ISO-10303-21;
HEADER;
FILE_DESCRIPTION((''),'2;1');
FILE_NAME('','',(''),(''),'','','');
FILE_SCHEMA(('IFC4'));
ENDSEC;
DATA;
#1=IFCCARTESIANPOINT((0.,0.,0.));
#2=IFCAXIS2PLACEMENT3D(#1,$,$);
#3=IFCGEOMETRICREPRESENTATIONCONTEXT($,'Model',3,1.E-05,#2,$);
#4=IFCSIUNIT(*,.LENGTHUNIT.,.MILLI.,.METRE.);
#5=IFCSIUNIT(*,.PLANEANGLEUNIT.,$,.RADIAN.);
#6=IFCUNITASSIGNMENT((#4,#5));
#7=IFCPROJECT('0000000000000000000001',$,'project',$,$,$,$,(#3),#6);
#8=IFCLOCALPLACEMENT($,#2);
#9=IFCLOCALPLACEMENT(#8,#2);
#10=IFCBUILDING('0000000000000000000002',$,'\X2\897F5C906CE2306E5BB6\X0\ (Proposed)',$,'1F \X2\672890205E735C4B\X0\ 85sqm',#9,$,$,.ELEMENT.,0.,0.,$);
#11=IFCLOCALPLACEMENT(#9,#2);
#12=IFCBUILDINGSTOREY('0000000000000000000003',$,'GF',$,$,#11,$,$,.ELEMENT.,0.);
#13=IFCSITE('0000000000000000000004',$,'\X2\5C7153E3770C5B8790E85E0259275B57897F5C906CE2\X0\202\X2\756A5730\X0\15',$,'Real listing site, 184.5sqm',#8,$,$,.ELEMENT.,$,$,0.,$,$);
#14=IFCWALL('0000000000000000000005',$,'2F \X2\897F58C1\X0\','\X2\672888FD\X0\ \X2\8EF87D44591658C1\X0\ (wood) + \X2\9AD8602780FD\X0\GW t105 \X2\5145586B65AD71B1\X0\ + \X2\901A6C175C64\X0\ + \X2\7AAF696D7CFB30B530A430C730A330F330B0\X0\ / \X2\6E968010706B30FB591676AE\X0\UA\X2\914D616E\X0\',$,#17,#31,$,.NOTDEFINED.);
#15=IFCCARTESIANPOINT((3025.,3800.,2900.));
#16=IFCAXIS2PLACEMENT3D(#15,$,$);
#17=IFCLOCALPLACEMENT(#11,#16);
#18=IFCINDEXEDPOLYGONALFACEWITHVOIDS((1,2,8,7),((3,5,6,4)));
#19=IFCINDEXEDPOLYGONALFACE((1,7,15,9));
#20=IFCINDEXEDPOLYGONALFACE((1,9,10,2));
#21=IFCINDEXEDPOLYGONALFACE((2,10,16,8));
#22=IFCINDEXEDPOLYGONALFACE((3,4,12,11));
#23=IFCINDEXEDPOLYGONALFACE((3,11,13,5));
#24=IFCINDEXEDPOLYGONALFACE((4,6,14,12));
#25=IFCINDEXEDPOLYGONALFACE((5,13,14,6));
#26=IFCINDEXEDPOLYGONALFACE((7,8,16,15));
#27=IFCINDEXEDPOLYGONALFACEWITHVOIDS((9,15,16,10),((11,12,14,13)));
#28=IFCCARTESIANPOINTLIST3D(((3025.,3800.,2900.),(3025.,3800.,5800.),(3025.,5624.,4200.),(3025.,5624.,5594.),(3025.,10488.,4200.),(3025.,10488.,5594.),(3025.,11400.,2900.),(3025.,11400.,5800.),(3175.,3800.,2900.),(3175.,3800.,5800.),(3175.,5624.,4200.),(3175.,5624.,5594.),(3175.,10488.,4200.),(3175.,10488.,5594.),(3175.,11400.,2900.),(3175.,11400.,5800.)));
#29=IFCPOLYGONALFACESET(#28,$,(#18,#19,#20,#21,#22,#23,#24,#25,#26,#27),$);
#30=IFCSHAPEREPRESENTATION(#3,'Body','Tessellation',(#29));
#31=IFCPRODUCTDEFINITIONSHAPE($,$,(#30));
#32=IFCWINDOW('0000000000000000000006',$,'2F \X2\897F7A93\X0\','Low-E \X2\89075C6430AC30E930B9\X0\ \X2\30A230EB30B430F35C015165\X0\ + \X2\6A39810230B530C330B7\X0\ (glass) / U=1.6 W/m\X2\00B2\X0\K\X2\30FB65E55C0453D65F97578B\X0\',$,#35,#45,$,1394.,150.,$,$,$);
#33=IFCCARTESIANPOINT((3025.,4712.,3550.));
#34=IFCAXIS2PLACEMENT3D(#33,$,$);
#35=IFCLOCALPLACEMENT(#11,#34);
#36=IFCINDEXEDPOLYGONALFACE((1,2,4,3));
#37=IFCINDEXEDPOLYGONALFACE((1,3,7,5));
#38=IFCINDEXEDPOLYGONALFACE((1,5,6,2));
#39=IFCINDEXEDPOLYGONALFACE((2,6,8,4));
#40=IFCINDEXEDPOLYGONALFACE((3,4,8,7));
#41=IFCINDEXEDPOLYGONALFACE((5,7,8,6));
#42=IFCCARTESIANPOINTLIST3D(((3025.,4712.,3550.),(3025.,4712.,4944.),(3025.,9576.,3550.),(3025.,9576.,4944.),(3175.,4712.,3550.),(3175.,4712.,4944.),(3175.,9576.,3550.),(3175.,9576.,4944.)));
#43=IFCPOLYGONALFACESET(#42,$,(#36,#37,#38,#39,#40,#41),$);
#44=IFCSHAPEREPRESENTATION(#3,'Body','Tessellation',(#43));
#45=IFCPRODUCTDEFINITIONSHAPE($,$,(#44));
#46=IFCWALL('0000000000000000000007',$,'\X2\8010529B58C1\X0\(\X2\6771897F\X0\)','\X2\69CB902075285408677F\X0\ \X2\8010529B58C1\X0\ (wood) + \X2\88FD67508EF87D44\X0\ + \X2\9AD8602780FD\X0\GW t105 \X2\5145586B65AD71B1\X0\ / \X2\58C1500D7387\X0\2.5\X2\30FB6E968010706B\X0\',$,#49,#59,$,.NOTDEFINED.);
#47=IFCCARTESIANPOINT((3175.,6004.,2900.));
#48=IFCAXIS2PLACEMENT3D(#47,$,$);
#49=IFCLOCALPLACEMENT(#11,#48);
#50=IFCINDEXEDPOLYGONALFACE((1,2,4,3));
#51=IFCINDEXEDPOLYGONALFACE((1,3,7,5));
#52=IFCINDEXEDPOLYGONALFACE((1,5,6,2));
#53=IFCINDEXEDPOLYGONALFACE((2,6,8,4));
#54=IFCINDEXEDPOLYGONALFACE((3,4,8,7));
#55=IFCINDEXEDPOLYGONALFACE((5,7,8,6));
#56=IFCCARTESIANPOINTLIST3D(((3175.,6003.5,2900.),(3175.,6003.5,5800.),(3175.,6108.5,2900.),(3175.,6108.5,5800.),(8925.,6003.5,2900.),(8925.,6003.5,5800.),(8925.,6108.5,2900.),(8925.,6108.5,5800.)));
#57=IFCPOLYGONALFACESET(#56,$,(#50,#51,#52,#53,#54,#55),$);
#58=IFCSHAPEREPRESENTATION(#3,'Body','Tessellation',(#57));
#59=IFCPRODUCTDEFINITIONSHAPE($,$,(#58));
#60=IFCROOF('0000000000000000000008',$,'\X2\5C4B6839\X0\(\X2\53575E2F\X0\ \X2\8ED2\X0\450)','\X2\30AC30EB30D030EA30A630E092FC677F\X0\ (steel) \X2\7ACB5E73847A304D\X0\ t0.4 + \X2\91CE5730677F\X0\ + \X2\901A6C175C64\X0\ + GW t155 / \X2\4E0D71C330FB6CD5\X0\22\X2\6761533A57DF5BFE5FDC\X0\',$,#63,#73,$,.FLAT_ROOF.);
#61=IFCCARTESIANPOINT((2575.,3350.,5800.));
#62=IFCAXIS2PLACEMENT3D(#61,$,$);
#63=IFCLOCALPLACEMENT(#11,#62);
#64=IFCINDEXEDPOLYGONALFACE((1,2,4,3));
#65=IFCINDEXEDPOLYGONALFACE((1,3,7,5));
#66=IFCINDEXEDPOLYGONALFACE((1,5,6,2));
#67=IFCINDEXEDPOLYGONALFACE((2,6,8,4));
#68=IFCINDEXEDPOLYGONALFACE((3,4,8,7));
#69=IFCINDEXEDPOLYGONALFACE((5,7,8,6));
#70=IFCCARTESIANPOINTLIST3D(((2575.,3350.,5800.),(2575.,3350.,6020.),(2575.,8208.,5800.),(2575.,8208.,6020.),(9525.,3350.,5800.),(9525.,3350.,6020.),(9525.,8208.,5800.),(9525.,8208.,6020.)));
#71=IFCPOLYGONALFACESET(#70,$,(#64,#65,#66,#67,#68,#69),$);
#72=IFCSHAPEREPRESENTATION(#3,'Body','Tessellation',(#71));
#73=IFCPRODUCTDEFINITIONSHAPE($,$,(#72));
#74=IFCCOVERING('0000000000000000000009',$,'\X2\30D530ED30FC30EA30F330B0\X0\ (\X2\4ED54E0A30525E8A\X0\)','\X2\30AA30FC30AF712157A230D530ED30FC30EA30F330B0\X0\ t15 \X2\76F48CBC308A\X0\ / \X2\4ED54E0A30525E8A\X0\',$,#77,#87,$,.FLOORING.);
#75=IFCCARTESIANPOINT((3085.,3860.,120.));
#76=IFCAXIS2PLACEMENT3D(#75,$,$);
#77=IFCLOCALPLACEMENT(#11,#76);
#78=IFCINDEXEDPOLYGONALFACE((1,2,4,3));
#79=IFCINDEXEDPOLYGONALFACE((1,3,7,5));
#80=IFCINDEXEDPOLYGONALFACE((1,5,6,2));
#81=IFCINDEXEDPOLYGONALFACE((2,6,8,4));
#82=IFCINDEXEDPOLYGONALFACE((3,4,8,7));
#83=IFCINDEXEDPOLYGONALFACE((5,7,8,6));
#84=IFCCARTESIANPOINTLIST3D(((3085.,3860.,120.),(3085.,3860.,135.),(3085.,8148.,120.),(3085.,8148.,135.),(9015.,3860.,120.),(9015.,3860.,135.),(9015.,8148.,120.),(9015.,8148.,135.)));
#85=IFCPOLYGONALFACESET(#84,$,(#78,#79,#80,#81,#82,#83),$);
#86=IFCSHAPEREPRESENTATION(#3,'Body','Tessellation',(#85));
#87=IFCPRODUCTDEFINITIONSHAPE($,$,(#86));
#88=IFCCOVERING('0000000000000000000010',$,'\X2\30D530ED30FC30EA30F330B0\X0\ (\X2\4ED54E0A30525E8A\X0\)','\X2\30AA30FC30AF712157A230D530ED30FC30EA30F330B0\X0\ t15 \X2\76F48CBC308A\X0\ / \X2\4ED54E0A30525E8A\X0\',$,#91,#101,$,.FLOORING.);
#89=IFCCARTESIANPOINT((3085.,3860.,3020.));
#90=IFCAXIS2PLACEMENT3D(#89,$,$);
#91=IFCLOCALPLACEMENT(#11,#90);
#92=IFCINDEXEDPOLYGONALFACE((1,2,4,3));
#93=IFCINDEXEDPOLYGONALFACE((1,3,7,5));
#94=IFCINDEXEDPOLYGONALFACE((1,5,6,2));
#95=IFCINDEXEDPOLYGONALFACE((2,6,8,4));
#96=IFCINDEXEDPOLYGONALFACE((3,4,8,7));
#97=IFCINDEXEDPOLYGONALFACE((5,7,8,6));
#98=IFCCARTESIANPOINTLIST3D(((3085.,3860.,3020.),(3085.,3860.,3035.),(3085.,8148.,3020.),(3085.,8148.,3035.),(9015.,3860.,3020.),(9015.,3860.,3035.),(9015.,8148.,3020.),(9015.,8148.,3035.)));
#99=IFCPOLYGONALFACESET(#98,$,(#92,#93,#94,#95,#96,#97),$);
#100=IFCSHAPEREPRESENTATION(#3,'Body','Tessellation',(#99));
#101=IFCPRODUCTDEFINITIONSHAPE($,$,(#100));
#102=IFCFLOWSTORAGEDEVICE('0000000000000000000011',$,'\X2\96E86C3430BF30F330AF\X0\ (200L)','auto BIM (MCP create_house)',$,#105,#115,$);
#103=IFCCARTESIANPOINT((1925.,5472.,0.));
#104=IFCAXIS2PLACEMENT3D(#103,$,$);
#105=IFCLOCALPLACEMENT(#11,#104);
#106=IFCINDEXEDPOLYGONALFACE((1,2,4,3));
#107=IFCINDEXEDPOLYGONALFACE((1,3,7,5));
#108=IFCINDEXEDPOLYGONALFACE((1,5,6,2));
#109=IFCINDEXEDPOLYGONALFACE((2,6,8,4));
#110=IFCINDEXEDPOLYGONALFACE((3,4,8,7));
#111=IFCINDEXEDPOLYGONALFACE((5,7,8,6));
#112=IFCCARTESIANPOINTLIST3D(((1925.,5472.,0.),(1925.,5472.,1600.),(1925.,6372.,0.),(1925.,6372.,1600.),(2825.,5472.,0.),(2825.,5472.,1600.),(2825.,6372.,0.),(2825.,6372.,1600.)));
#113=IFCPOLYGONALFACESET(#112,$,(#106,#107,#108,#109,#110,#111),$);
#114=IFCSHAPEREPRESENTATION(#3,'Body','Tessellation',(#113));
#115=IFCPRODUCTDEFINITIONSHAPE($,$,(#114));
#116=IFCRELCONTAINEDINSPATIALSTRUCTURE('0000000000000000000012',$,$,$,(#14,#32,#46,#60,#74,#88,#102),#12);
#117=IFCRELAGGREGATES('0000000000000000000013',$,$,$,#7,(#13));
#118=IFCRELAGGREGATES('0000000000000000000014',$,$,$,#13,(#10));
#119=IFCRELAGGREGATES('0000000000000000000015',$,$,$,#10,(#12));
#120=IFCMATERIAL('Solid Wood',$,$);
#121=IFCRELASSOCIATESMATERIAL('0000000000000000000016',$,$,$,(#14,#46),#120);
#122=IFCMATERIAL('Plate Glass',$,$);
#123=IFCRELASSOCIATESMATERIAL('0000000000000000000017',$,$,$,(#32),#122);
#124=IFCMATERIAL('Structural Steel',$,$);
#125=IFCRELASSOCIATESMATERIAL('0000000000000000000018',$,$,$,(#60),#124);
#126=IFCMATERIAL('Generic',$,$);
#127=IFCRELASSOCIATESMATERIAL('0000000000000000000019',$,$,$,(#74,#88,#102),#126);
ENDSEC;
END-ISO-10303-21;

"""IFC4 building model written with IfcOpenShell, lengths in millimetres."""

from ifc_helpers import new_model, si_unit, frame, frame_2d, origin, place, context, project, spatial, rectangle, extrude, material, element, fill, save


model = new_model("IFC4")

# Units and contexts
model_context = context("Model", 3, precision=1e-05, world=origin())
ifc_project = project(units=[si_unit("LENGTHUNIT", "METRE", prefix="MILLI"), si_unit("PLANEANGLEUNIT", "RADIAN")], contexts=[model_context])

# Site, building, storey
site_placement = place(None, origin())
site = spatial("IfcSite", under=ifc_project, at=site_placement, Name="山口県宇部市大字西岐波202番地15", ObjectType="Real listing site, 184.5sqm", CompositionType="ELEMENT", RefElevation=0.0)
building_placement = place(site_placement, origin())
building = spatial("IfcBuilding", under=site, at=building_placement, Name="西岐波の家 (Proposed)", ObjectType="1F 木造平屋 85sqm", CompositionType="ELEMENT", ElevationOfRefHeight=0.0, ElevationOfTerrain=0.0)
storey_placement = place(building_placement, origin())
storey = spatial("IfcBuildingStorey", under=building, at=storey_placement, Name="GF", CompositionType="ELEMENT", Elevation=0.0)

# Shared definitions
ifc_material_1 = material(Name="Solid Wood")
ifc_material_2 = material(Name="Generic")

# Shared definitions
ifc_material_3 = material(Name="Plate Glass")

# Wall, opening, window
wall_1_placement = place(storey_placement, frame((3025.0, 3800.0, 2900.0)))
wall_1 = element("IfcWall", 1, at=wall_1_placement, inside=storey, material=ifc_material_1, Name="2F 西壁", Description="木製 軸組外壁 (wood) + 高性能GW t105 充填断熱 + 通気層 + 窯業系サイディング / 準耐火・外皮UA配慮", PredefinedType="NOTDEFINED", context=model_context, shape_type="SweptSolid", body=[
    extrude(rectangle(XDim=150.0, YDim=7600.0, at=frame_2d((75.0, 3800.0))), frame((3025.0, 3800.0, 2900.0)), (0.0, 0.0, 1.0), 2900.0),
])
opening_1_placement = place(storey_placement, frame((3025.0, 4712.0, 3550.0)))
opening_1 = element("IfcOpeningElement", 2, at=opening_1_placement, cuts=wall_1, PredefinedType="NOTDEFINED", context=model_context, shape_type="SweptSolid", body=[
    extrude(rectangle(XDim=150.0, YDim=4864.0, at=frame_2d((75.0, 2432.0))), frame((3025.0, 4712.0, 3550.0)), (0.0, 0.0, 1.0), 1394.0),
])
window_1_placement = place(storey_placement, frame((3025.0, 4712.0, 3550.0)))
window_1 = element("IfcWindow", 3, at=window_1_placement, inside=storey, material=ifc_material_3, Name="2F 西窓", Description="Low-E 複層ガラス アルゴン封入 + 樹脂サッシ (glass) / U=1.6 W/m²K・日射取得型", OverallHeight=1394.0, OverallWidth=150.0, context=model_context, shape_type="SweptSolid", body=[
    extrude(rectangle(XDim=150.0, YDim=4864.0, at=frame_2d((75.0, 2432.0))), frame((3025.0, 4712.0, 3550.0)), (0.0, 0.0, 1.0), 1394.0),
])
fill(opening_1, window_1)

# Wall
wall_2_placement = place(storey_placement, frame((3175.0, 6004.0, 2900.0)))
element("IfcWall", 4, at=wall_2_placement, inside=storey, material=ifc_material_1, Name="耐力壁(東西)", Description="構造用合板 耐力壁 (wood) + 製材軸組 + 高性能GW t105 充填断熱 / 壁倍率2.5・準耐火", PredefinedType="NOTDEFINED", context=model_context, shape_type="SweptSolid", body=[
    extrude(rectangle(XDim=5750.0, YDim=105.0, at=frame_2d((2875.0, 52.0))), frame((3175.0, 6004.0, 2900.0)), (0.0, 0.0, 1.0), 2900.0),
])

# Roof
ifc_material_4 = material(Name="Structural Steel")
for number, where, name in (
    (5, (2575.0, 3350.0, 5800.0), "屋根(南帯 軒450)"),
):
    element("IfcRoof", number, at=place(storey_placement, frame(where)), inside=storey, material=ifc_material_4, Name=name, Description="ガルバリウム鋼板 (steel) 立平葺き t0.4 + 野地板 + 通気層 + GW t155 / 不燃・法22条区域対応", PredefinedType="FLAT_ROOF", context=model_context, shape_type="SweptSolid", body=[
        extrude(rectangle(XDim=6950.0, YDim=4858.0, at=frame_2d((3475.0, 2429.0))), frame((2575.0, 3350.0, 5800.0)), (0.0, 0.0, 1.0), 220.0),
    ])

# Coverings
covering_1_placement = place(storey_placement, frame((3085.0, 3860.0, 120.0)))
element("IfcCovering", 6, at=covering_1_placement, inside=storey, material=ifc_material_2, Name="フローリング (仕上げ床)", Description="オーク無垢フローリング t15 直貼り / 仕上げ床", PredefinedType="FLOORING", context=model_context, shape_type="SweptSolid", body=[
    extrude(rectangle(XDim=5930.0, YDim=4288.0, at=frame_2d((2965.0, 2144.0))), frame((3085.0, 3860.0, 120.0)), (0.0, 0.0, 1.0), 15.0),
])
covering_2_placement = place(storey_placement, frame((3085.0, 3860.0, 3020.0)))
element("IfcCovering", 7, at=covering_2_placement, inside=storey, material=ifc_material_2, Name="フローリング (仕上げ床)", Description="オーク無垢フローリング t15 直貼り / 仕上げ床", PredefinedType="FLOORING", context=model_context, shape_type="SweptSolid", body=[
    extrude(rectangle(XDim=5930.0, YDim=4288.0, at=frame_2d((2965.0, 2144.0))), frame((3085.0, 3860.0, 3020.0)), (0.0, 0.0, 1.0), 15.0),
])

# Flow storage device
flow_storage_device_placement = place(storey_placement, frame((1925.0, 5472.0, 0.0)))
element("IfcFlowStorageDevice", 8, at=flow_storage_device_placement, inside=storey, material=ifc_material_2, Name="雨水タンク (200L)", Description="auto BIM (MCP create_house)", context=model_context, shape_type="SweptSolid", body=[
    extrude(rectangle(XDim=900.0, YDim=900.0, at=frame_2d((450.0, 450.0))), frame((1925.0, 5472.0, 0.0)), (0.0, 0.0, 1.0), 1600.0),
])

save(model, "model.ifc")
